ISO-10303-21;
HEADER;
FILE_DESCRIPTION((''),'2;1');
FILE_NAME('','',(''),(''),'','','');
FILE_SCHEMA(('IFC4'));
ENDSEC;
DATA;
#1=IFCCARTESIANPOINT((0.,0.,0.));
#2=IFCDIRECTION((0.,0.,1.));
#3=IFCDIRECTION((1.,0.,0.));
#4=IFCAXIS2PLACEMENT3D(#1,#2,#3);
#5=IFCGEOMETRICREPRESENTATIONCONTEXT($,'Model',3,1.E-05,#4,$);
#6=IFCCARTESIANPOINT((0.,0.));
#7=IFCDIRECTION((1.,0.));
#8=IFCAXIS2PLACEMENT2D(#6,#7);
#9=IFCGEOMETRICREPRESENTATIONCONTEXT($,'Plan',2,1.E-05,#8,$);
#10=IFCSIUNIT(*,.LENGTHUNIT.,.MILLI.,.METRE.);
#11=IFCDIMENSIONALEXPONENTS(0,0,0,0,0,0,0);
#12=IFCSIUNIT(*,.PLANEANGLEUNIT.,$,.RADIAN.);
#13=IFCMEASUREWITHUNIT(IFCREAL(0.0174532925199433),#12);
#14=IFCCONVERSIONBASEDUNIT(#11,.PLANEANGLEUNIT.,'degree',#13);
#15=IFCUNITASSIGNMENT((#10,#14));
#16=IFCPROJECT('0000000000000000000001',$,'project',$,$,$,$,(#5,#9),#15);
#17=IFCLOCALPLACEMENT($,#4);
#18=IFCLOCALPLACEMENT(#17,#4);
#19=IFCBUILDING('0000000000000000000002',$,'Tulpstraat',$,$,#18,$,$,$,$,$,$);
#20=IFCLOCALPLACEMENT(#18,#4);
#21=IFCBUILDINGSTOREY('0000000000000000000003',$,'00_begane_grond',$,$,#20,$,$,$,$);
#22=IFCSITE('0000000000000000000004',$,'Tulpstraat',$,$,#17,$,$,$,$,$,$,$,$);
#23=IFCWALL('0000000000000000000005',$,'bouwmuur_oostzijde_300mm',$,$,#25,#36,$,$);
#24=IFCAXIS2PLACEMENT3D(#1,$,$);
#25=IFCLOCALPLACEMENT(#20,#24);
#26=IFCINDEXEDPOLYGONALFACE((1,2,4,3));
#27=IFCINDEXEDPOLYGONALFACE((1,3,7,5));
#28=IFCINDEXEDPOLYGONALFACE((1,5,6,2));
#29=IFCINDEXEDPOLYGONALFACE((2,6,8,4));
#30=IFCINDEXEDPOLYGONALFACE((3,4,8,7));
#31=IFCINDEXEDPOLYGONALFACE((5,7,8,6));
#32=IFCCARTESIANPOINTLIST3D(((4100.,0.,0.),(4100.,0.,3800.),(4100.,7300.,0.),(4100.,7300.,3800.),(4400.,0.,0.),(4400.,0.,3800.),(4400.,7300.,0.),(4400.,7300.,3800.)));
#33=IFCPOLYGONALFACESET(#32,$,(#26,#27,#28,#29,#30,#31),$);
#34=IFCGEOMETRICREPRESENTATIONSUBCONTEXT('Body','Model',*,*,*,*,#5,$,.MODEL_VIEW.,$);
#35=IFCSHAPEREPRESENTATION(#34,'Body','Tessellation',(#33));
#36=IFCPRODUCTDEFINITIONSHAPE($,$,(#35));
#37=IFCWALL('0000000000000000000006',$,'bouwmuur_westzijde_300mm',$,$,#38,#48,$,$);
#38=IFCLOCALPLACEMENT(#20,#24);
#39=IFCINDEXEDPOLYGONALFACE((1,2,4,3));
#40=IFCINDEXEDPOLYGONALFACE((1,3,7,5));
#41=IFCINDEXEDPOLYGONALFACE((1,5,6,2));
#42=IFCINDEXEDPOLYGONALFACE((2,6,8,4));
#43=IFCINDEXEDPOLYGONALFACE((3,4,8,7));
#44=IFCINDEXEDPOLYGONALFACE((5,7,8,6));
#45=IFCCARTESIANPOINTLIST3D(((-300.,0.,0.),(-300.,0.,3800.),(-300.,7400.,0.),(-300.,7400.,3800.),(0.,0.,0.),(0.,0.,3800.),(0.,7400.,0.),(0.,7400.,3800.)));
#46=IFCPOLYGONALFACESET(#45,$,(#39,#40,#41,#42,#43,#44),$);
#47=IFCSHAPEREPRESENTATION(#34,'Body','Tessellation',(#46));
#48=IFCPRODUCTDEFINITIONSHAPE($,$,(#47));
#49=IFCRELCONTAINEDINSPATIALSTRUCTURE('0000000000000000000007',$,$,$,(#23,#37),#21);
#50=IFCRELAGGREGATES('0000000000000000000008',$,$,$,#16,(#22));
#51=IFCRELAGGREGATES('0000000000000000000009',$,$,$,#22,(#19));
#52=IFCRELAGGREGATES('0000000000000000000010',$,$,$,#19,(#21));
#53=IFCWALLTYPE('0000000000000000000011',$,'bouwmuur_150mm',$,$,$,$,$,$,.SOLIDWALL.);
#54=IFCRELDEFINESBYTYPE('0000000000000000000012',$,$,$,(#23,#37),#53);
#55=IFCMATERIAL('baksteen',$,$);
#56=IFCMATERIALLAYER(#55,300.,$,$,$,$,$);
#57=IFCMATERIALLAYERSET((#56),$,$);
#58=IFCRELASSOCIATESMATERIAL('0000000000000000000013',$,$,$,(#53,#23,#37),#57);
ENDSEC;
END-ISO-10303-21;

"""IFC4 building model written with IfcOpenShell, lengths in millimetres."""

from ifc_helpers import new_model, entity, si_unit, converted_unit, frame, origin_with_axes, origin_2d_with_axis, place, context, subcontext, project, spatial, indexed_curve, outline, extrude, material, layer, layer_set, layer_usage, type_object, element, save


model = new_model("IFC4")

# Units and contexts
model_context = context("Model", 3, precision=1e-05, world=origin_with_axes())
plan_context = context("Plan", 2, precision=1e-05, world=origin_2d_with_axis())
body_context = subcontext(model_context, "Body", "Model", "MODEL_VIEW")
ifc_project = project(units=[si_unit("LENGTHUNIT", "METRE", prefix="MILLI"), converted_unit("PLANEANGLEUNIT", "degree", entity("IfcReal", 0.0174532925199433), si_unit("PLANEANGLEUNIT", "RADIAN"), dimensions=[0, 0, 0, 0, 0, 0, 0])], contexts=[model_context, plan_context])

# Site, building, storey
site_placement = place(None, origin_with_axes())
site = spatial("IfcSite", under=ifc_project, at=site_placement, Name="Tulpstraat")
building_placement = place(site_placement, origin_with_axes())
building = spatial("IfcBuilding", under=site, at=building_placement, Name="Tulpstraat")
storey_placement = place(building_placement, origin_with_axes())
storey = spatial("IfcBuildingStorey", under=building, at=storey_placement, Name="00_begane_grond")

# Walls
ifc_material = material(Name="baksteen")
ifc_layer = layer(ifc_material, 300.0)
ifc_layer_set = layer_set([ifc_layer])
ifc_layer_usage_1 = layer_usage(ifc_layer_set, "AXIS2", "POSITIVE", 0.0)
wall_type = type_object("IfcWallType", Name="bouwmuur_150mm", PredefinedType="SOLIDWALL", material=ifc_layer_set)
wall_1_placement = place(storey_placement, frame((4100.0, 7300.0, 0.0), z_axis=(0.0, 0.0, 1.0), x_axis=(0.0, -1.0, 0.0)))
element("IfcWall", 1, at=wall_1_placement, inside=storey, type_object=wall_type, material=ifc_layer_usage_1, Name="bouwmuur_oostzijde_300mm", context=body_context, shape_type="SweptSolid", body=[
    extrude(outline(indexed_curve([(0.0, 0.0), (0.0, 300.0), (7300.0, 300.0), (7300.0, 0.0), (0.0, 0.0)], self_intersect=False)), origin_with_axes(), (0.0, 0.0, 1.0), 3800.0),
])
ifc_layer_usage_2 = layer_usage(ifc_layer_set, "AXIS2", "POSITIVE", 0.0)
wall_2_placement = place(storey_placement, frame((0.0, 0.0, 0.0), z_axis=(0.0, 0.0, 1.0), x_axis=(0.0, 1.0, 0.0)))
element("IfcWall", 2, at=wall_2_placement, inside=storey, type_object=wall_type, material=ifc_layer_usage_2, Name="bouwmuur_westzijde_300mm", context=body_context, shape_type="SweptSolid", body=[
    extrude(outline(indexed_curve([(0.0, 0.0), (0.0, 300.0), (7400.0, 300.0), (7400.0, 0.0), (0.0, 0.0)], self_intersect=False)), origin_with_axes(), (0.0, 0.0, 1.0), 3800.0),
])

save(model, "model.ifc")
